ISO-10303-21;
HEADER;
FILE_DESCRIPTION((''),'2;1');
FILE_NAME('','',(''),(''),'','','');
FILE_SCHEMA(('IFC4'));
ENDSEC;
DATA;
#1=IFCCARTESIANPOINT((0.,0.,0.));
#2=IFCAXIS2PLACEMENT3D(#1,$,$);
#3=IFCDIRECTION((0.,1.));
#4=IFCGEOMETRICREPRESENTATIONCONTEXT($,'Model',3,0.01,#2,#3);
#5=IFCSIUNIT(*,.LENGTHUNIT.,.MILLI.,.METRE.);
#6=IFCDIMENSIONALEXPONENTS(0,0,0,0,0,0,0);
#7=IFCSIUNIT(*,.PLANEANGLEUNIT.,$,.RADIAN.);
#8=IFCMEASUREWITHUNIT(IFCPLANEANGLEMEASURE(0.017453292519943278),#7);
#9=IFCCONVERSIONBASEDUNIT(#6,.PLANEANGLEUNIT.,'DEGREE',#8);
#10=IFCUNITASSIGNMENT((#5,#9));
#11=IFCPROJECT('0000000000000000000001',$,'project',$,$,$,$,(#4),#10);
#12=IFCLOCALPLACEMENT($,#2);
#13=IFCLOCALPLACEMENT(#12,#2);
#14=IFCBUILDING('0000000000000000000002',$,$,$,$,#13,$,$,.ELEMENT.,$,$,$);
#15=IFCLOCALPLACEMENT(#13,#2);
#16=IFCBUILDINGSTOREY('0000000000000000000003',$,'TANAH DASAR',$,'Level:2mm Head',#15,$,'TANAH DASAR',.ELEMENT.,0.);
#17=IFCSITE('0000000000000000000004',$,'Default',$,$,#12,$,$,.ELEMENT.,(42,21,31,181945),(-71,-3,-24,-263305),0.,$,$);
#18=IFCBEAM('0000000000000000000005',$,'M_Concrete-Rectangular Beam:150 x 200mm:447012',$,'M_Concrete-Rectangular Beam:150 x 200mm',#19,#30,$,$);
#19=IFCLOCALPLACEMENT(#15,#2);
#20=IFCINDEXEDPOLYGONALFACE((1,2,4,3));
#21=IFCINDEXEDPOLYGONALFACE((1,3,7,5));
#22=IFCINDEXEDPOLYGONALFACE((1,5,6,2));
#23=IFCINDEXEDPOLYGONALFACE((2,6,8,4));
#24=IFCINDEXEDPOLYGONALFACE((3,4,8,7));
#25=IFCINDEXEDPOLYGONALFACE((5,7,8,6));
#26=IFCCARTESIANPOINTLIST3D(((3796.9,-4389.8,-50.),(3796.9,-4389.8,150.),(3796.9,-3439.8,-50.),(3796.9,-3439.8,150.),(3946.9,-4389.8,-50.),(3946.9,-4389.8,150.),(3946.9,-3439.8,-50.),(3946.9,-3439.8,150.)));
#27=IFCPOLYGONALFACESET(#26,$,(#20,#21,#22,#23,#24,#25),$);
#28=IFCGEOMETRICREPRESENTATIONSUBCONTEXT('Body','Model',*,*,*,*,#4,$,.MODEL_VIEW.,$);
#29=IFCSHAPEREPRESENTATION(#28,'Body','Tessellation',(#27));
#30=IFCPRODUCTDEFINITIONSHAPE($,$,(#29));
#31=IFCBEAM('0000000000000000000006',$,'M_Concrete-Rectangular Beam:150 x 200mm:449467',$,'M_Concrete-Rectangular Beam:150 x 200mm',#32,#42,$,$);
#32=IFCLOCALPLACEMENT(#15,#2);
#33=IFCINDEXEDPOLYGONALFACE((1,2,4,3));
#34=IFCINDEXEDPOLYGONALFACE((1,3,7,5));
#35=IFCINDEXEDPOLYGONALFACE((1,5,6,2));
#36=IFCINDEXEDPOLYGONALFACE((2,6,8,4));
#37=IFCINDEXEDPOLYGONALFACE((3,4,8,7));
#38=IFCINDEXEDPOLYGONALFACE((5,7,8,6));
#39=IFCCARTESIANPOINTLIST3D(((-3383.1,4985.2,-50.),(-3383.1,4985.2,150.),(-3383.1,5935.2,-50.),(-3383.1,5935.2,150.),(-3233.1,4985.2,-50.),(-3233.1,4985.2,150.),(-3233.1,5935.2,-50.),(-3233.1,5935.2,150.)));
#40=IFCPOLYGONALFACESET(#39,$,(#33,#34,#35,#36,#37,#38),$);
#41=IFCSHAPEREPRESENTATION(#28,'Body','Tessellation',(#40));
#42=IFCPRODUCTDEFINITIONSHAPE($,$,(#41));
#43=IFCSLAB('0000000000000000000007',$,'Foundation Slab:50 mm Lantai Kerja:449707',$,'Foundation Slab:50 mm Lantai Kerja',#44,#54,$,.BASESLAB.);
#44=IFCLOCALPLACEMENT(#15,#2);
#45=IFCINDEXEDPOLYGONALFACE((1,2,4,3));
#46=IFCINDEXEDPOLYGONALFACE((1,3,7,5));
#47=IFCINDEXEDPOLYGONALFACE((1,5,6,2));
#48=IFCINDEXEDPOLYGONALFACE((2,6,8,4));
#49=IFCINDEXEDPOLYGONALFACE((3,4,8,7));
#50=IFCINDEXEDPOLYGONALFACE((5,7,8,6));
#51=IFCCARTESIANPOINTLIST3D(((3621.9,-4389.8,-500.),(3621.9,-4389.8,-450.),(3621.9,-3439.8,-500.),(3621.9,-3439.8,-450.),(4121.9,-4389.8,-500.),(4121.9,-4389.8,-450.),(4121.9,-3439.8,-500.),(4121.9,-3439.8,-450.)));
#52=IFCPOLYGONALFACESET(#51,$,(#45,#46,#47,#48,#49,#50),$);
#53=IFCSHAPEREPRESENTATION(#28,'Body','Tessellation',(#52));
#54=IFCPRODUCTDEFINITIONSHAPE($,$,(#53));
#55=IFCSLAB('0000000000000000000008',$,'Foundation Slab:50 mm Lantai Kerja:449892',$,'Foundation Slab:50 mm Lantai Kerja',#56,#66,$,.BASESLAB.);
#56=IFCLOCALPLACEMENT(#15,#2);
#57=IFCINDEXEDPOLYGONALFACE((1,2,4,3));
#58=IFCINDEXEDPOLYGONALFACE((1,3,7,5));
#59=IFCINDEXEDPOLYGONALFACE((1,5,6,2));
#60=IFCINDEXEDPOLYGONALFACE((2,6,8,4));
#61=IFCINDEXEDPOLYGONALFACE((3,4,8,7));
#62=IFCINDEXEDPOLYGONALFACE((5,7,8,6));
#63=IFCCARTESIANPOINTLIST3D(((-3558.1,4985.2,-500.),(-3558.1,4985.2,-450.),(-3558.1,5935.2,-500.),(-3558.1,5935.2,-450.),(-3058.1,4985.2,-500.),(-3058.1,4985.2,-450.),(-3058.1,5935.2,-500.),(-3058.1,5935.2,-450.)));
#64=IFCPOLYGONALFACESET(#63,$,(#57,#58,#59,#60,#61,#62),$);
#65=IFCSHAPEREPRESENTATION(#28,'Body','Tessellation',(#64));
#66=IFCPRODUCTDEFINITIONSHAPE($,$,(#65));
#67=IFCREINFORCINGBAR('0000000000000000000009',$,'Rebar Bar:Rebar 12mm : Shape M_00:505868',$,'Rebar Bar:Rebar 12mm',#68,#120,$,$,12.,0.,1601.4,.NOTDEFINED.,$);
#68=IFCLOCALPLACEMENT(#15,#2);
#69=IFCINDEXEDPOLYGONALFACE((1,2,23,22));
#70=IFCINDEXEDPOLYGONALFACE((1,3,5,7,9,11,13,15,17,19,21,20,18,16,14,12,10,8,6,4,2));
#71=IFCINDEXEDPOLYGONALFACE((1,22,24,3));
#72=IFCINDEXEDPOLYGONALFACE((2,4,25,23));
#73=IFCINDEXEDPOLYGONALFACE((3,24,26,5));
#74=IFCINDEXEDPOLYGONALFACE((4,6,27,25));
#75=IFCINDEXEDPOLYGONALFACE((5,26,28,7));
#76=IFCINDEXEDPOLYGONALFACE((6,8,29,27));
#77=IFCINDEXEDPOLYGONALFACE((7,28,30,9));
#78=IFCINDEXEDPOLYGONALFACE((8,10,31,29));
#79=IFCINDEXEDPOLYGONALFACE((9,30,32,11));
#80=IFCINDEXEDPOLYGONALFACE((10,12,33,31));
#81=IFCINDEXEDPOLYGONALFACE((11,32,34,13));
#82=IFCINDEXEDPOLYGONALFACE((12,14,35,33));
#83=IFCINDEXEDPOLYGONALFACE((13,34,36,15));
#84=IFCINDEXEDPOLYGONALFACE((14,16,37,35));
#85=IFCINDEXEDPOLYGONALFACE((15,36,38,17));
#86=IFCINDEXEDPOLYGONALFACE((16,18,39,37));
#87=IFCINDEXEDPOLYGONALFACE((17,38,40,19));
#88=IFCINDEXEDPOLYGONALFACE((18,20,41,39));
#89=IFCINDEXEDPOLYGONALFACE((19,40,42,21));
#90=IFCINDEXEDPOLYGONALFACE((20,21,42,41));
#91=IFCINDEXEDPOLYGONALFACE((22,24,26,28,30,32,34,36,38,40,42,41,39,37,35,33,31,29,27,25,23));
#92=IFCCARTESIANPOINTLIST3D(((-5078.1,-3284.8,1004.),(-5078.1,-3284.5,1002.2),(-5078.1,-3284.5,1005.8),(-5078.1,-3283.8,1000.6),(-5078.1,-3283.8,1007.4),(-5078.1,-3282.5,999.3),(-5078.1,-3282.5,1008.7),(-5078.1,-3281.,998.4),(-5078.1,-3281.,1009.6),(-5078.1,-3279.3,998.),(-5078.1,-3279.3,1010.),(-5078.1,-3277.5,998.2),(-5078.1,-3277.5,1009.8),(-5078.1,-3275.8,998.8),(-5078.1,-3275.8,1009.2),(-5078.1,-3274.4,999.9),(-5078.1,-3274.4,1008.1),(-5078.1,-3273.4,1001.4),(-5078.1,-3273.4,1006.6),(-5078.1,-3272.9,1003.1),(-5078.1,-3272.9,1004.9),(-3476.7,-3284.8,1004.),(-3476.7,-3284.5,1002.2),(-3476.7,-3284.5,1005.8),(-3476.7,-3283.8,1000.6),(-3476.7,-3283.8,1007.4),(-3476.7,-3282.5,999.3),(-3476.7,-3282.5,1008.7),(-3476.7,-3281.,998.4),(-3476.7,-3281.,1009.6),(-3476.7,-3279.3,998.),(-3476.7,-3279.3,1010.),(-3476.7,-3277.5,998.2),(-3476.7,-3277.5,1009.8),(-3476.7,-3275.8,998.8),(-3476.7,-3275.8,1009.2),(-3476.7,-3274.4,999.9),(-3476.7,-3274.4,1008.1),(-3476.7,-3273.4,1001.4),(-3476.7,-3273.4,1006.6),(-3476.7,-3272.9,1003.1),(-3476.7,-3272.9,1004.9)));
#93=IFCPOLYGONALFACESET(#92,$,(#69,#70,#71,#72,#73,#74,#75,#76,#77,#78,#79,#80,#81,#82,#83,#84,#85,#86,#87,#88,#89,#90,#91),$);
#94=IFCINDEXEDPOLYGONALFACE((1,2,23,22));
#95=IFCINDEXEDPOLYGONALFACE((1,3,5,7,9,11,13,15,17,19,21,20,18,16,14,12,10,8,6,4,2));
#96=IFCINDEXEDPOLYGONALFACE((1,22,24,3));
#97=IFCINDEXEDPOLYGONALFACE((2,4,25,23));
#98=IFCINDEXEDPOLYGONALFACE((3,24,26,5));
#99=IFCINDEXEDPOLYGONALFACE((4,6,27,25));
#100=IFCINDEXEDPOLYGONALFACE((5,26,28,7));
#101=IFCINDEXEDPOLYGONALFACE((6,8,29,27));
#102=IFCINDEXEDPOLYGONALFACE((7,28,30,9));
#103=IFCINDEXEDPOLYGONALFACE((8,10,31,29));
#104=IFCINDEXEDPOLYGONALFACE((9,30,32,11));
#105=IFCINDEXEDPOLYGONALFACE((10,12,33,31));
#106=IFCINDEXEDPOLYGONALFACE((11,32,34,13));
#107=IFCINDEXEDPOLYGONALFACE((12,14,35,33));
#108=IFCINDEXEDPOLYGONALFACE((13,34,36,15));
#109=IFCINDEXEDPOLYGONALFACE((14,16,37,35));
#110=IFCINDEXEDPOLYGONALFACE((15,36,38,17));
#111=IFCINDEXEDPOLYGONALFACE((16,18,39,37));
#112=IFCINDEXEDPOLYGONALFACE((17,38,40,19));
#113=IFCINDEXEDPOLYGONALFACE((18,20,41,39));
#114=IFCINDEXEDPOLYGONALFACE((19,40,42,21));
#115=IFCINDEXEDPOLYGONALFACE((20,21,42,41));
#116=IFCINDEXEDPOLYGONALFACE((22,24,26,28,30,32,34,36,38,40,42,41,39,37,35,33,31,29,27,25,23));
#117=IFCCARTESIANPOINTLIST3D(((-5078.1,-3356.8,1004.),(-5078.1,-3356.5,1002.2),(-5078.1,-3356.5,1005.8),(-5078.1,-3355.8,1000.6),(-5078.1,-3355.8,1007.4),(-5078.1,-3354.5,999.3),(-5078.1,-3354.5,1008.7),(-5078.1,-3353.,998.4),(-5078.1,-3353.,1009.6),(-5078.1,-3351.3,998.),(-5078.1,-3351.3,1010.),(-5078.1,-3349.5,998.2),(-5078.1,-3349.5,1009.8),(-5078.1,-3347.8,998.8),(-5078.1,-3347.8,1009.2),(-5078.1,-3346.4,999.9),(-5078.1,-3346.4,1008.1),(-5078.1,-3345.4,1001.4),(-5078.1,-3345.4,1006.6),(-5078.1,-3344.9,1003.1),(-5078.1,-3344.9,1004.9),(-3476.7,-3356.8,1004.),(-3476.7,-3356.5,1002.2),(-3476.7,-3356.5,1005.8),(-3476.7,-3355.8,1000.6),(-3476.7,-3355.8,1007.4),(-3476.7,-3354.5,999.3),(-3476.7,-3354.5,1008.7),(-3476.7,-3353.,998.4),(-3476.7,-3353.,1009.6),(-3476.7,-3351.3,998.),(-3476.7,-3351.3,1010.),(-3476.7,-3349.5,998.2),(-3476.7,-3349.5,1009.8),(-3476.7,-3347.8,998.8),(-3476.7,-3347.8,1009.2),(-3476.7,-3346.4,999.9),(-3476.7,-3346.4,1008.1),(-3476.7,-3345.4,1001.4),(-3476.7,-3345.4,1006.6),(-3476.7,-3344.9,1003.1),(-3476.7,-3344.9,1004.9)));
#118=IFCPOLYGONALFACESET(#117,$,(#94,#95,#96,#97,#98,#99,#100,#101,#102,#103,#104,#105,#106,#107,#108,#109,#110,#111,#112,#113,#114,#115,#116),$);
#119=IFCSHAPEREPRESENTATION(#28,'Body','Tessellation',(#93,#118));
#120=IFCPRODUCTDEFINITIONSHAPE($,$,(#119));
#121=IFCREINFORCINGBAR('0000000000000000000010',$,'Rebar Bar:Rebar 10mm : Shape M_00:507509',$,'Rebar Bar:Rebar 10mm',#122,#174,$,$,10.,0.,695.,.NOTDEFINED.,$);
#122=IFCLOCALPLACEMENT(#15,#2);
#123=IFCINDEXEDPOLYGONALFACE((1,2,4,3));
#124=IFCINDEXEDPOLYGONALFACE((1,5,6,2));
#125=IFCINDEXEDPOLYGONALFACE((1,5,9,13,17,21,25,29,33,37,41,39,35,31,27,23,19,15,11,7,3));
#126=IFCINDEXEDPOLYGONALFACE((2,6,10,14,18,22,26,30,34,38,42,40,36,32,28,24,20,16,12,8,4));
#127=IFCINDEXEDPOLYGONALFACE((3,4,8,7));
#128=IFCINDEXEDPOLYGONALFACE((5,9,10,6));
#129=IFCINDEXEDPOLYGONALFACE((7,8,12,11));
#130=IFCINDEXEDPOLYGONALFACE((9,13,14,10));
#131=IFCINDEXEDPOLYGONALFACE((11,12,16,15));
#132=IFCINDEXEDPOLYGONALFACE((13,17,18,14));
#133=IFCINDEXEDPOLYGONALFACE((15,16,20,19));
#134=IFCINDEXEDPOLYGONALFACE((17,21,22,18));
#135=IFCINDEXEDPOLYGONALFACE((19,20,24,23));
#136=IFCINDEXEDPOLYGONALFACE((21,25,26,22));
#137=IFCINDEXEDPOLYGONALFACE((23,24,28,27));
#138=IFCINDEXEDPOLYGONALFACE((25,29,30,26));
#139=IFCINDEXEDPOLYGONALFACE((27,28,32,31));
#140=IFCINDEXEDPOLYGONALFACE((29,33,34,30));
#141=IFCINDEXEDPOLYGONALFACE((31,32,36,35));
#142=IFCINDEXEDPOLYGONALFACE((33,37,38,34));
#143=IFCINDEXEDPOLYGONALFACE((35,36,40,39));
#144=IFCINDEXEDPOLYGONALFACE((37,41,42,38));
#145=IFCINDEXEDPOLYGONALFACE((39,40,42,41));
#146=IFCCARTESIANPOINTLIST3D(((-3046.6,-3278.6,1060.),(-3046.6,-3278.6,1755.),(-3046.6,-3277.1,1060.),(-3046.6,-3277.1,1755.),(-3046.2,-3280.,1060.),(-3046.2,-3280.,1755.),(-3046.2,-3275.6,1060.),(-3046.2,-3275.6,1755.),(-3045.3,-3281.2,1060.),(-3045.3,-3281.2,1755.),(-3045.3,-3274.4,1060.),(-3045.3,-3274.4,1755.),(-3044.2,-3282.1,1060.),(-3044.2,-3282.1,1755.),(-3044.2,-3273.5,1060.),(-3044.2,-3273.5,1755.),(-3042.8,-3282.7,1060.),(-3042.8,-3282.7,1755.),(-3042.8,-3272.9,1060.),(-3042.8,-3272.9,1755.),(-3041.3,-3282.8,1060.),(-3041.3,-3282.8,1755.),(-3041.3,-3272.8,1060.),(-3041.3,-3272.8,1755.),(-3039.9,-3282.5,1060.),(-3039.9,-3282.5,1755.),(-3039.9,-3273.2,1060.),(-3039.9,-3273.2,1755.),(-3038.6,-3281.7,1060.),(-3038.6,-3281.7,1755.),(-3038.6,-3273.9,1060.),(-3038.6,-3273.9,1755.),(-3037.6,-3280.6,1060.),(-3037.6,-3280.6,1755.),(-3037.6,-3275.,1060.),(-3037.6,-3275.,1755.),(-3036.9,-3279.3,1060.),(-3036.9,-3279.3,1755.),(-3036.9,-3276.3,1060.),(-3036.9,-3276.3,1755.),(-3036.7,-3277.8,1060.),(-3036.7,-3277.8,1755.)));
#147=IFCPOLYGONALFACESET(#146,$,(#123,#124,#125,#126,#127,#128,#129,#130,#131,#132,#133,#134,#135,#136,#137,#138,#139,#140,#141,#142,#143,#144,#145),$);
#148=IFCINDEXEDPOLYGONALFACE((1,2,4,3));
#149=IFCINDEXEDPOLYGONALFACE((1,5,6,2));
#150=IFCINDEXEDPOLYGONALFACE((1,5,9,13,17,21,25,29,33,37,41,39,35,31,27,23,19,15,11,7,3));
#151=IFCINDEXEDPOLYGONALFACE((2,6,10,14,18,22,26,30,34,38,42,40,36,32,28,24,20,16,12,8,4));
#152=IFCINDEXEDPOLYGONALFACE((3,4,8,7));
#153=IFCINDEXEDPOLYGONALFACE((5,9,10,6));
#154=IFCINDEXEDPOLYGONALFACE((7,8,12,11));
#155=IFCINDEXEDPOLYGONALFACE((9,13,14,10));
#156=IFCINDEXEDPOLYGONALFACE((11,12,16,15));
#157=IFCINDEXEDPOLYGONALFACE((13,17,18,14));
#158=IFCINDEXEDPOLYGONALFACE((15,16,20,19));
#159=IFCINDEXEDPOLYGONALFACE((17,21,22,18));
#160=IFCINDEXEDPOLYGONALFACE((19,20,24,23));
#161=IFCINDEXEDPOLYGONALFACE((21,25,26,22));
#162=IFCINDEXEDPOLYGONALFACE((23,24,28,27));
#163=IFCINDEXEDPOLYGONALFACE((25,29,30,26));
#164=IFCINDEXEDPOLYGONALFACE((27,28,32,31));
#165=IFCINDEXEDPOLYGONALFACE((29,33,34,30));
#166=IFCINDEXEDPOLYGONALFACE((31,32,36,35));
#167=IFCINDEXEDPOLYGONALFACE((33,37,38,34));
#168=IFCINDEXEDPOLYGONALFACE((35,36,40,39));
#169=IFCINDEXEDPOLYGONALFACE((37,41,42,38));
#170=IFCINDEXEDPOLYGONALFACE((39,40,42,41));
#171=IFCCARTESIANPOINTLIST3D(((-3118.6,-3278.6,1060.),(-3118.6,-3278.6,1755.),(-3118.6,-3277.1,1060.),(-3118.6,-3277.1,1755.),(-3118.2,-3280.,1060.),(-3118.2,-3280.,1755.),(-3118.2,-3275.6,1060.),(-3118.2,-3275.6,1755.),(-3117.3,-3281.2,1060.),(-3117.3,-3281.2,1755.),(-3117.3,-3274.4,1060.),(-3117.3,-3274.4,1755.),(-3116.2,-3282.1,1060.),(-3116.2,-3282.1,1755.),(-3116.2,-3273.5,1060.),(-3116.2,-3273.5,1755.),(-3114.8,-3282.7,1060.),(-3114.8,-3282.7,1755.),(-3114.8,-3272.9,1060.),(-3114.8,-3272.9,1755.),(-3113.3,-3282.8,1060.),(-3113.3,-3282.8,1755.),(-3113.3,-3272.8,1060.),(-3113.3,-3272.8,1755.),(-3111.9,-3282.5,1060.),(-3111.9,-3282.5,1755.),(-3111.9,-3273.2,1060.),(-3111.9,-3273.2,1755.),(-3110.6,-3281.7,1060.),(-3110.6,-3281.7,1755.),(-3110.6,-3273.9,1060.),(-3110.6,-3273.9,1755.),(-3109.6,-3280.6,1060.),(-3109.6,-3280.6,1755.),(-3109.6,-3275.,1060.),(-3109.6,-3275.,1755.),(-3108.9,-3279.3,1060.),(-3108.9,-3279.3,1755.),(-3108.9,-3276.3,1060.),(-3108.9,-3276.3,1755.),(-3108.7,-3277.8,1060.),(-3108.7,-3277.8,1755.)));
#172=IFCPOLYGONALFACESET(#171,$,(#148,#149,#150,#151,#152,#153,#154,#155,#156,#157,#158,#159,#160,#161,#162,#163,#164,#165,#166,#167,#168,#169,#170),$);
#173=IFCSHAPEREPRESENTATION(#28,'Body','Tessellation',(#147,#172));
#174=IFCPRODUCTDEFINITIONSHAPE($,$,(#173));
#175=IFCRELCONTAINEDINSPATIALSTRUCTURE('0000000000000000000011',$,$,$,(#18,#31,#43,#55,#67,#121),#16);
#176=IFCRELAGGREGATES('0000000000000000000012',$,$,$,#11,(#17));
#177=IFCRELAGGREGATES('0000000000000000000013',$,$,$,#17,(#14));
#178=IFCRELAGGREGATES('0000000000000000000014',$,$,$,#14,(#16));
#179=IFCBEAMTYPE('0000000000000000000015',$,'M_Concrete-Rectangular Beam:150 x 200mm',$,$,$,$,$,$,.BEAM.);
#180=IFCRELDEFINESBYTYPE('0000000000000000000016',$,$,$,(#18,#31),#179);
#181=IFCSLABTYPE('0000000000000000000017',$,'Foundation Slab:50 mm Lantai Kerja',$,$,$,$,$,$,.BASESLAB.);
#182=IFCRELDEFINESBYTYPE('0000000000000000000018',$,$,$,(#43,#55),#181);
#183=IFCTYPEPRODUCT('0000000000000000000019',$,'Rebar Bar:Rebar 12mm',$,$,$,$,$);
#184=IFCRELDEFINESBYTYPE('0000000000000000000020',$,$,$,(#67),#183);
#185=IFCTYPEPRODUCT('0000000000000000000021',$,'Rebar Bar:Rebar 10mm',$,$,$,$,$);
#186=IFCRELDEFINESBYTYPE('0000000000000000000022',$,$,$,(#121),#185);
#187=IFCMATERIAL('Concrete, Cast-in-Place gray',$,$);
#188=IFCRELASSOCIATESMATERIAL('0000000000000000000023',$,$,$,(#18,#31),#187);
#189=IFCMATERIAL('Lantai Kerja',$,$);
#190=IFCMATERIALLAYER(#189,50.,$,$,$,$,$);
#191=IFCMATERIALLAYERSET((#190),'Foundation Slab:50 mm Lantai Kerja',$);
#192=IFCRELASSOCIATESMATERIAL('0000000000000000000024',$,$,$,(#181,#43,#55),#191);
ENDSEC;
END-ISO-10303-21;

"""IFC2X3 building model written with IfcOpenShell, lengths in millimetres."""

from ifc_helpers import new_model, entity, si_unit, converted_unit, direction, frame, frame_2d, origin, origin_2d_with_axis, place, context, subcontext, project, spatial, rectangle, extrude, material, layer, layer_set, layer_usage, type_object, element, save


model = new_model("IFC2X3")

# Units and contexts
model_context = context("Model", 3, precision=0.01, world=origin(), true_north=direction((0.0, 1.0)))
body_context = subcontext(model_context, "Body", "Model", "MODEL_VIEW")
ifc_project = project(units=[si_unit("LENGTHUNIT", "METRE", prefix="MILLI"), converted_unit("PLANEANGLEUNIT", "DEGREE", entity("IfcPlaneAngleMeasure", 0.017453292519943278), si_unit("PLANEANGLEUNIT", "RADIAN"), dimensions=[0, 0, 0, 0, 0, 0, 0])], contexts=[model_context])

# Site, building, storey
site_placement = place(None, origin())
site = spatial("IfcSite", under=ifc_project, at=site_placement, Name="Default", CompositionType="ELEMENT", RefLatitude=(42, 21, 31, 181945), RefLongitude=(-71, -3, -24, -263305), RefElevation=0.0)
building_placement = place(site_placement, origin())
building = spatial("IfcBuilding", under=site, at=building_placement, CompositionType="ELEMENT")
storey_placement = place(building_placement, origin())
storey = spatial("IfcBuildingStorey", under=building, at=storey_placement, Name="TANAH DASAR", ObjectType="Level:2mm Head", LongName="TANAH DASAR", CompositionType="ELEMENT", Elevation=0.0)

# Beams
ifc_material_1 = material(Name="Concrete, Cast-in-Place gray")
beam_type = type_object("IfcBeamType", Name="M_Concrete-Rectangular Beam:150 x 200mm", PredefinedType="BEAM")
beam_1_placement = place(storey_placement, frame((3871.9, -3439.8, 150.0), z_axis=(0.0, 0.0, 1.0), x_axis=(0.0, -1.0, 0.0)))
element("IfcBeam", 1, at=beam_1_placement, inside=storey, type_object=beam_type, material=ifc_material_1, Name="M_Concrete-Rectangular Beam:150 x 200mm:447012", ObjectType="M_Concrete-Rectangular Beam:150 x 200mm", context=body_context, shape_type="SweptSolid", body=[
    extrude(rectangle(XDim=200.0, YDim=150.0, at=frame_2d((0.0, 0.0), x_axis=(1.0, 0.0))), frame((0.0, 0.0, -100.0), z_axis=(1.0, 0.0, 0.0), x_axis=(0.0, 0.0, -1.0)), (0.0, 0.0, 1.0), 950.0),
])
beam_2_placement = place(storey_placement, frame((-3308.1, 4985.2, 150.0), z_axis=(0.0, 0.0, 1.0), x_axis=(0.0, 1.0, 0.0)))
element("IfcBeam", 2, at=beam_2_placement, inside=storey, type_object=beam_type, material=ifc_material_1, Name="M_Concrete-Rectangular Beam:150 x 200mm:449467", ObjectType="M_Concrete-Rectangular Beam:150 x 200mm", context=body_context, shape_type="SweptSolid", body=[
    extrude(rectangle(XDim=200.0, YDim=150.0, at=frame_2d((0.0, 0.0), x_axis=(1.0, 0.0))), frame((0.0, 0.0, -100.0), z_axis=(1.0, 0.0, 0.0), x_axis=(0.0, 0.0, -1.0)), (0.0, 0.0, 1.0), 950.0),
])

# Slabs
ifc_material_2 = material(Name="Lantai Kerja")
ifc_layer = layer(ifc_material_2, 50.0)
ifc_layer_set = layer_set([ifc_layer], Name="Foundation Slab:50 mm Lantai Kerja")
ifc_layer_usage_1 = layer_usage(ifc_layer_set, "AXIS3", "POSITIVE", 0.0)
slab_type = type_object("IfcSlabType", Name="Foundation Slab:50 mm Lantai Kerja", PredefinedType="BASESLAB", material=ifc_layer_set)
slab_1_placement = place(storey_placement, origin())
element("IfcSlab", 3, at=slab_1_placement, inside=storey, type_object=slab_type, material=ifc_layer_usage_1, Name="Foundation Slab:50 mm Lantai Kerja:449707", ObjectType="Foundation Slab:50 mm Lantai Kerja", PredefinedType="BASESLAB", context=body_context, shape_type="SweptSolid", body=[
    extrude(rectangle(XDim=950.0, YDim=500.0, at=frame_2d((0.0, 0.0), x_axis=(1.0, 0.0))), frame((3871.9, -3914.8, -450.0), z_axis=(0.0, 0.0, -1.0), x_axis=(0.0, 1.0, 0.0)), (0.0, 0.0, 1.0), 50.0),
])
ifc_layer_usage_2 = layer_usage(ifc_layer_set, "AXIS3", "POSITIVE", 0.0)
slab_2_placement = place(storey_placement, origin())
element("IfcSlab", 4, at=slab_2_placement, inside=storey, type_object=slab_type, material=ifc_layer_usage_2, Name="Foundation Slab:50 mm Lantai Kerja:449892", ObjectType="Foundation Slab:50 mm Lantai Kerja", PredefinedType="BASESLAB", context=body_context, shape_type="SweptSolid", body=[
    extrude(rectangle(XDim=950.0, YDim=500.0, at=origin_2d_with_axis()), frame((-3308.1, 5460.2, -450.0), z_axis=(0.0, 0.0, -1.0), x_axis=(0.0, 1.0, 0.0)), (0.0, 0.0, 1.0), 50.0),
])

# Reinforcing bars
type_product_1 = type_object("IfcTypeProduct", Name="Rebar Bar:Rebar 12mm")
reinforcing_bar_1_placement = place(storey_placement, origin())
element("IfcReinforcingBar", 5, at=reinforcing_bar_1_placement, inside=storey, type_object=type_product_1, Name="Rebar Bar:Rebar 12mm : Shape M_00:505868", ObjectType="Rebar Bar:Rebar 12mm", BarLength=1601.4, BarRole="NOTDEFINED", CrossSectionArea=0.0, NominalDiameter=12.0, context=body_context, shape_type="AdvancedSweptSolid", body=[
    entity("IfcSweptDiskSolid", entity("IfcCompositeCurve", [entity("IfcCompositeCurveSegment", "CONTINUOUS", True, entity("IfcPolyline", [entity("IfcCartesianPoint", [-3476.7, -3278.8, 1004.0]), entity("IfcCartesianPoint", [-5078.1, -3278.8, 1004.0])]))], False), 6.0, None, 0.0, 1.0),
    entity("IfcSweptDiskSolid", entity("IfcCompositeCurve", [entity("IfcCompositeCurveSegment", "CONTINUOUS", True, entity("IfcPolyline", [entity("IfcCartesianPoint", [-3476.7, -3350.8, 1004.0]), entity("IfcCartesianPoint", [-5078.1, -3350.8, 1004.0])]))], False), 6.0, None, 0.0, 1.0),
])
type_product_2 = type_object("IfcTypeProduct", Name="Rebar Bar:Rebar 10mm")
reinforcing_bar_2_placement = place(storey_placement, origin())
element("IfcReinforcingBar", 6, at=reinforcing_bar_2_placement, inside=storey, type_object=type_product_2, Name="Rebar Bar:Rebar 10mm : Shape M_00:507509", ObjectType="Rebar Bar:Rebar 10mm", BarLength=695.0, BarRole="NOTDEFINED", CrossSectionArea=0.0, NominalDiameter=10.0, context=body_context, shape_type="AdvancedSweptSolid", body=[
    entity("IfcSweptDiskSolid", entity("IfcCompositeCurve", [entity("IfcCompositeCurveSegment", "CONTINUOUS", True, entity("IfcPolyline", [entity("IfcCartesianPoint", [-3041.7, -3277.8, 1060.0]), entity("IfcCartesianPoint", [-3041.7, -3277.8, 1755.0])]))], False), 5.0, None, 0.0, 1.0),
    entity("IfcSweptDiskSolid", entity("IfcCompositeCurve", [entity("IfcCompositeCurveSegment", "CONTINUOUS", True, entity("IfcPolyline", [entity("IfcCartesianPoint", [-3113.7, -3277.8, 1060.0]), entity("IfcCartesianPoint", [-3113.7, -3277.8, 1755.0])]))], False), 5.0, None, 0.0, 1.0),
])

save(model, "model.ifc")
